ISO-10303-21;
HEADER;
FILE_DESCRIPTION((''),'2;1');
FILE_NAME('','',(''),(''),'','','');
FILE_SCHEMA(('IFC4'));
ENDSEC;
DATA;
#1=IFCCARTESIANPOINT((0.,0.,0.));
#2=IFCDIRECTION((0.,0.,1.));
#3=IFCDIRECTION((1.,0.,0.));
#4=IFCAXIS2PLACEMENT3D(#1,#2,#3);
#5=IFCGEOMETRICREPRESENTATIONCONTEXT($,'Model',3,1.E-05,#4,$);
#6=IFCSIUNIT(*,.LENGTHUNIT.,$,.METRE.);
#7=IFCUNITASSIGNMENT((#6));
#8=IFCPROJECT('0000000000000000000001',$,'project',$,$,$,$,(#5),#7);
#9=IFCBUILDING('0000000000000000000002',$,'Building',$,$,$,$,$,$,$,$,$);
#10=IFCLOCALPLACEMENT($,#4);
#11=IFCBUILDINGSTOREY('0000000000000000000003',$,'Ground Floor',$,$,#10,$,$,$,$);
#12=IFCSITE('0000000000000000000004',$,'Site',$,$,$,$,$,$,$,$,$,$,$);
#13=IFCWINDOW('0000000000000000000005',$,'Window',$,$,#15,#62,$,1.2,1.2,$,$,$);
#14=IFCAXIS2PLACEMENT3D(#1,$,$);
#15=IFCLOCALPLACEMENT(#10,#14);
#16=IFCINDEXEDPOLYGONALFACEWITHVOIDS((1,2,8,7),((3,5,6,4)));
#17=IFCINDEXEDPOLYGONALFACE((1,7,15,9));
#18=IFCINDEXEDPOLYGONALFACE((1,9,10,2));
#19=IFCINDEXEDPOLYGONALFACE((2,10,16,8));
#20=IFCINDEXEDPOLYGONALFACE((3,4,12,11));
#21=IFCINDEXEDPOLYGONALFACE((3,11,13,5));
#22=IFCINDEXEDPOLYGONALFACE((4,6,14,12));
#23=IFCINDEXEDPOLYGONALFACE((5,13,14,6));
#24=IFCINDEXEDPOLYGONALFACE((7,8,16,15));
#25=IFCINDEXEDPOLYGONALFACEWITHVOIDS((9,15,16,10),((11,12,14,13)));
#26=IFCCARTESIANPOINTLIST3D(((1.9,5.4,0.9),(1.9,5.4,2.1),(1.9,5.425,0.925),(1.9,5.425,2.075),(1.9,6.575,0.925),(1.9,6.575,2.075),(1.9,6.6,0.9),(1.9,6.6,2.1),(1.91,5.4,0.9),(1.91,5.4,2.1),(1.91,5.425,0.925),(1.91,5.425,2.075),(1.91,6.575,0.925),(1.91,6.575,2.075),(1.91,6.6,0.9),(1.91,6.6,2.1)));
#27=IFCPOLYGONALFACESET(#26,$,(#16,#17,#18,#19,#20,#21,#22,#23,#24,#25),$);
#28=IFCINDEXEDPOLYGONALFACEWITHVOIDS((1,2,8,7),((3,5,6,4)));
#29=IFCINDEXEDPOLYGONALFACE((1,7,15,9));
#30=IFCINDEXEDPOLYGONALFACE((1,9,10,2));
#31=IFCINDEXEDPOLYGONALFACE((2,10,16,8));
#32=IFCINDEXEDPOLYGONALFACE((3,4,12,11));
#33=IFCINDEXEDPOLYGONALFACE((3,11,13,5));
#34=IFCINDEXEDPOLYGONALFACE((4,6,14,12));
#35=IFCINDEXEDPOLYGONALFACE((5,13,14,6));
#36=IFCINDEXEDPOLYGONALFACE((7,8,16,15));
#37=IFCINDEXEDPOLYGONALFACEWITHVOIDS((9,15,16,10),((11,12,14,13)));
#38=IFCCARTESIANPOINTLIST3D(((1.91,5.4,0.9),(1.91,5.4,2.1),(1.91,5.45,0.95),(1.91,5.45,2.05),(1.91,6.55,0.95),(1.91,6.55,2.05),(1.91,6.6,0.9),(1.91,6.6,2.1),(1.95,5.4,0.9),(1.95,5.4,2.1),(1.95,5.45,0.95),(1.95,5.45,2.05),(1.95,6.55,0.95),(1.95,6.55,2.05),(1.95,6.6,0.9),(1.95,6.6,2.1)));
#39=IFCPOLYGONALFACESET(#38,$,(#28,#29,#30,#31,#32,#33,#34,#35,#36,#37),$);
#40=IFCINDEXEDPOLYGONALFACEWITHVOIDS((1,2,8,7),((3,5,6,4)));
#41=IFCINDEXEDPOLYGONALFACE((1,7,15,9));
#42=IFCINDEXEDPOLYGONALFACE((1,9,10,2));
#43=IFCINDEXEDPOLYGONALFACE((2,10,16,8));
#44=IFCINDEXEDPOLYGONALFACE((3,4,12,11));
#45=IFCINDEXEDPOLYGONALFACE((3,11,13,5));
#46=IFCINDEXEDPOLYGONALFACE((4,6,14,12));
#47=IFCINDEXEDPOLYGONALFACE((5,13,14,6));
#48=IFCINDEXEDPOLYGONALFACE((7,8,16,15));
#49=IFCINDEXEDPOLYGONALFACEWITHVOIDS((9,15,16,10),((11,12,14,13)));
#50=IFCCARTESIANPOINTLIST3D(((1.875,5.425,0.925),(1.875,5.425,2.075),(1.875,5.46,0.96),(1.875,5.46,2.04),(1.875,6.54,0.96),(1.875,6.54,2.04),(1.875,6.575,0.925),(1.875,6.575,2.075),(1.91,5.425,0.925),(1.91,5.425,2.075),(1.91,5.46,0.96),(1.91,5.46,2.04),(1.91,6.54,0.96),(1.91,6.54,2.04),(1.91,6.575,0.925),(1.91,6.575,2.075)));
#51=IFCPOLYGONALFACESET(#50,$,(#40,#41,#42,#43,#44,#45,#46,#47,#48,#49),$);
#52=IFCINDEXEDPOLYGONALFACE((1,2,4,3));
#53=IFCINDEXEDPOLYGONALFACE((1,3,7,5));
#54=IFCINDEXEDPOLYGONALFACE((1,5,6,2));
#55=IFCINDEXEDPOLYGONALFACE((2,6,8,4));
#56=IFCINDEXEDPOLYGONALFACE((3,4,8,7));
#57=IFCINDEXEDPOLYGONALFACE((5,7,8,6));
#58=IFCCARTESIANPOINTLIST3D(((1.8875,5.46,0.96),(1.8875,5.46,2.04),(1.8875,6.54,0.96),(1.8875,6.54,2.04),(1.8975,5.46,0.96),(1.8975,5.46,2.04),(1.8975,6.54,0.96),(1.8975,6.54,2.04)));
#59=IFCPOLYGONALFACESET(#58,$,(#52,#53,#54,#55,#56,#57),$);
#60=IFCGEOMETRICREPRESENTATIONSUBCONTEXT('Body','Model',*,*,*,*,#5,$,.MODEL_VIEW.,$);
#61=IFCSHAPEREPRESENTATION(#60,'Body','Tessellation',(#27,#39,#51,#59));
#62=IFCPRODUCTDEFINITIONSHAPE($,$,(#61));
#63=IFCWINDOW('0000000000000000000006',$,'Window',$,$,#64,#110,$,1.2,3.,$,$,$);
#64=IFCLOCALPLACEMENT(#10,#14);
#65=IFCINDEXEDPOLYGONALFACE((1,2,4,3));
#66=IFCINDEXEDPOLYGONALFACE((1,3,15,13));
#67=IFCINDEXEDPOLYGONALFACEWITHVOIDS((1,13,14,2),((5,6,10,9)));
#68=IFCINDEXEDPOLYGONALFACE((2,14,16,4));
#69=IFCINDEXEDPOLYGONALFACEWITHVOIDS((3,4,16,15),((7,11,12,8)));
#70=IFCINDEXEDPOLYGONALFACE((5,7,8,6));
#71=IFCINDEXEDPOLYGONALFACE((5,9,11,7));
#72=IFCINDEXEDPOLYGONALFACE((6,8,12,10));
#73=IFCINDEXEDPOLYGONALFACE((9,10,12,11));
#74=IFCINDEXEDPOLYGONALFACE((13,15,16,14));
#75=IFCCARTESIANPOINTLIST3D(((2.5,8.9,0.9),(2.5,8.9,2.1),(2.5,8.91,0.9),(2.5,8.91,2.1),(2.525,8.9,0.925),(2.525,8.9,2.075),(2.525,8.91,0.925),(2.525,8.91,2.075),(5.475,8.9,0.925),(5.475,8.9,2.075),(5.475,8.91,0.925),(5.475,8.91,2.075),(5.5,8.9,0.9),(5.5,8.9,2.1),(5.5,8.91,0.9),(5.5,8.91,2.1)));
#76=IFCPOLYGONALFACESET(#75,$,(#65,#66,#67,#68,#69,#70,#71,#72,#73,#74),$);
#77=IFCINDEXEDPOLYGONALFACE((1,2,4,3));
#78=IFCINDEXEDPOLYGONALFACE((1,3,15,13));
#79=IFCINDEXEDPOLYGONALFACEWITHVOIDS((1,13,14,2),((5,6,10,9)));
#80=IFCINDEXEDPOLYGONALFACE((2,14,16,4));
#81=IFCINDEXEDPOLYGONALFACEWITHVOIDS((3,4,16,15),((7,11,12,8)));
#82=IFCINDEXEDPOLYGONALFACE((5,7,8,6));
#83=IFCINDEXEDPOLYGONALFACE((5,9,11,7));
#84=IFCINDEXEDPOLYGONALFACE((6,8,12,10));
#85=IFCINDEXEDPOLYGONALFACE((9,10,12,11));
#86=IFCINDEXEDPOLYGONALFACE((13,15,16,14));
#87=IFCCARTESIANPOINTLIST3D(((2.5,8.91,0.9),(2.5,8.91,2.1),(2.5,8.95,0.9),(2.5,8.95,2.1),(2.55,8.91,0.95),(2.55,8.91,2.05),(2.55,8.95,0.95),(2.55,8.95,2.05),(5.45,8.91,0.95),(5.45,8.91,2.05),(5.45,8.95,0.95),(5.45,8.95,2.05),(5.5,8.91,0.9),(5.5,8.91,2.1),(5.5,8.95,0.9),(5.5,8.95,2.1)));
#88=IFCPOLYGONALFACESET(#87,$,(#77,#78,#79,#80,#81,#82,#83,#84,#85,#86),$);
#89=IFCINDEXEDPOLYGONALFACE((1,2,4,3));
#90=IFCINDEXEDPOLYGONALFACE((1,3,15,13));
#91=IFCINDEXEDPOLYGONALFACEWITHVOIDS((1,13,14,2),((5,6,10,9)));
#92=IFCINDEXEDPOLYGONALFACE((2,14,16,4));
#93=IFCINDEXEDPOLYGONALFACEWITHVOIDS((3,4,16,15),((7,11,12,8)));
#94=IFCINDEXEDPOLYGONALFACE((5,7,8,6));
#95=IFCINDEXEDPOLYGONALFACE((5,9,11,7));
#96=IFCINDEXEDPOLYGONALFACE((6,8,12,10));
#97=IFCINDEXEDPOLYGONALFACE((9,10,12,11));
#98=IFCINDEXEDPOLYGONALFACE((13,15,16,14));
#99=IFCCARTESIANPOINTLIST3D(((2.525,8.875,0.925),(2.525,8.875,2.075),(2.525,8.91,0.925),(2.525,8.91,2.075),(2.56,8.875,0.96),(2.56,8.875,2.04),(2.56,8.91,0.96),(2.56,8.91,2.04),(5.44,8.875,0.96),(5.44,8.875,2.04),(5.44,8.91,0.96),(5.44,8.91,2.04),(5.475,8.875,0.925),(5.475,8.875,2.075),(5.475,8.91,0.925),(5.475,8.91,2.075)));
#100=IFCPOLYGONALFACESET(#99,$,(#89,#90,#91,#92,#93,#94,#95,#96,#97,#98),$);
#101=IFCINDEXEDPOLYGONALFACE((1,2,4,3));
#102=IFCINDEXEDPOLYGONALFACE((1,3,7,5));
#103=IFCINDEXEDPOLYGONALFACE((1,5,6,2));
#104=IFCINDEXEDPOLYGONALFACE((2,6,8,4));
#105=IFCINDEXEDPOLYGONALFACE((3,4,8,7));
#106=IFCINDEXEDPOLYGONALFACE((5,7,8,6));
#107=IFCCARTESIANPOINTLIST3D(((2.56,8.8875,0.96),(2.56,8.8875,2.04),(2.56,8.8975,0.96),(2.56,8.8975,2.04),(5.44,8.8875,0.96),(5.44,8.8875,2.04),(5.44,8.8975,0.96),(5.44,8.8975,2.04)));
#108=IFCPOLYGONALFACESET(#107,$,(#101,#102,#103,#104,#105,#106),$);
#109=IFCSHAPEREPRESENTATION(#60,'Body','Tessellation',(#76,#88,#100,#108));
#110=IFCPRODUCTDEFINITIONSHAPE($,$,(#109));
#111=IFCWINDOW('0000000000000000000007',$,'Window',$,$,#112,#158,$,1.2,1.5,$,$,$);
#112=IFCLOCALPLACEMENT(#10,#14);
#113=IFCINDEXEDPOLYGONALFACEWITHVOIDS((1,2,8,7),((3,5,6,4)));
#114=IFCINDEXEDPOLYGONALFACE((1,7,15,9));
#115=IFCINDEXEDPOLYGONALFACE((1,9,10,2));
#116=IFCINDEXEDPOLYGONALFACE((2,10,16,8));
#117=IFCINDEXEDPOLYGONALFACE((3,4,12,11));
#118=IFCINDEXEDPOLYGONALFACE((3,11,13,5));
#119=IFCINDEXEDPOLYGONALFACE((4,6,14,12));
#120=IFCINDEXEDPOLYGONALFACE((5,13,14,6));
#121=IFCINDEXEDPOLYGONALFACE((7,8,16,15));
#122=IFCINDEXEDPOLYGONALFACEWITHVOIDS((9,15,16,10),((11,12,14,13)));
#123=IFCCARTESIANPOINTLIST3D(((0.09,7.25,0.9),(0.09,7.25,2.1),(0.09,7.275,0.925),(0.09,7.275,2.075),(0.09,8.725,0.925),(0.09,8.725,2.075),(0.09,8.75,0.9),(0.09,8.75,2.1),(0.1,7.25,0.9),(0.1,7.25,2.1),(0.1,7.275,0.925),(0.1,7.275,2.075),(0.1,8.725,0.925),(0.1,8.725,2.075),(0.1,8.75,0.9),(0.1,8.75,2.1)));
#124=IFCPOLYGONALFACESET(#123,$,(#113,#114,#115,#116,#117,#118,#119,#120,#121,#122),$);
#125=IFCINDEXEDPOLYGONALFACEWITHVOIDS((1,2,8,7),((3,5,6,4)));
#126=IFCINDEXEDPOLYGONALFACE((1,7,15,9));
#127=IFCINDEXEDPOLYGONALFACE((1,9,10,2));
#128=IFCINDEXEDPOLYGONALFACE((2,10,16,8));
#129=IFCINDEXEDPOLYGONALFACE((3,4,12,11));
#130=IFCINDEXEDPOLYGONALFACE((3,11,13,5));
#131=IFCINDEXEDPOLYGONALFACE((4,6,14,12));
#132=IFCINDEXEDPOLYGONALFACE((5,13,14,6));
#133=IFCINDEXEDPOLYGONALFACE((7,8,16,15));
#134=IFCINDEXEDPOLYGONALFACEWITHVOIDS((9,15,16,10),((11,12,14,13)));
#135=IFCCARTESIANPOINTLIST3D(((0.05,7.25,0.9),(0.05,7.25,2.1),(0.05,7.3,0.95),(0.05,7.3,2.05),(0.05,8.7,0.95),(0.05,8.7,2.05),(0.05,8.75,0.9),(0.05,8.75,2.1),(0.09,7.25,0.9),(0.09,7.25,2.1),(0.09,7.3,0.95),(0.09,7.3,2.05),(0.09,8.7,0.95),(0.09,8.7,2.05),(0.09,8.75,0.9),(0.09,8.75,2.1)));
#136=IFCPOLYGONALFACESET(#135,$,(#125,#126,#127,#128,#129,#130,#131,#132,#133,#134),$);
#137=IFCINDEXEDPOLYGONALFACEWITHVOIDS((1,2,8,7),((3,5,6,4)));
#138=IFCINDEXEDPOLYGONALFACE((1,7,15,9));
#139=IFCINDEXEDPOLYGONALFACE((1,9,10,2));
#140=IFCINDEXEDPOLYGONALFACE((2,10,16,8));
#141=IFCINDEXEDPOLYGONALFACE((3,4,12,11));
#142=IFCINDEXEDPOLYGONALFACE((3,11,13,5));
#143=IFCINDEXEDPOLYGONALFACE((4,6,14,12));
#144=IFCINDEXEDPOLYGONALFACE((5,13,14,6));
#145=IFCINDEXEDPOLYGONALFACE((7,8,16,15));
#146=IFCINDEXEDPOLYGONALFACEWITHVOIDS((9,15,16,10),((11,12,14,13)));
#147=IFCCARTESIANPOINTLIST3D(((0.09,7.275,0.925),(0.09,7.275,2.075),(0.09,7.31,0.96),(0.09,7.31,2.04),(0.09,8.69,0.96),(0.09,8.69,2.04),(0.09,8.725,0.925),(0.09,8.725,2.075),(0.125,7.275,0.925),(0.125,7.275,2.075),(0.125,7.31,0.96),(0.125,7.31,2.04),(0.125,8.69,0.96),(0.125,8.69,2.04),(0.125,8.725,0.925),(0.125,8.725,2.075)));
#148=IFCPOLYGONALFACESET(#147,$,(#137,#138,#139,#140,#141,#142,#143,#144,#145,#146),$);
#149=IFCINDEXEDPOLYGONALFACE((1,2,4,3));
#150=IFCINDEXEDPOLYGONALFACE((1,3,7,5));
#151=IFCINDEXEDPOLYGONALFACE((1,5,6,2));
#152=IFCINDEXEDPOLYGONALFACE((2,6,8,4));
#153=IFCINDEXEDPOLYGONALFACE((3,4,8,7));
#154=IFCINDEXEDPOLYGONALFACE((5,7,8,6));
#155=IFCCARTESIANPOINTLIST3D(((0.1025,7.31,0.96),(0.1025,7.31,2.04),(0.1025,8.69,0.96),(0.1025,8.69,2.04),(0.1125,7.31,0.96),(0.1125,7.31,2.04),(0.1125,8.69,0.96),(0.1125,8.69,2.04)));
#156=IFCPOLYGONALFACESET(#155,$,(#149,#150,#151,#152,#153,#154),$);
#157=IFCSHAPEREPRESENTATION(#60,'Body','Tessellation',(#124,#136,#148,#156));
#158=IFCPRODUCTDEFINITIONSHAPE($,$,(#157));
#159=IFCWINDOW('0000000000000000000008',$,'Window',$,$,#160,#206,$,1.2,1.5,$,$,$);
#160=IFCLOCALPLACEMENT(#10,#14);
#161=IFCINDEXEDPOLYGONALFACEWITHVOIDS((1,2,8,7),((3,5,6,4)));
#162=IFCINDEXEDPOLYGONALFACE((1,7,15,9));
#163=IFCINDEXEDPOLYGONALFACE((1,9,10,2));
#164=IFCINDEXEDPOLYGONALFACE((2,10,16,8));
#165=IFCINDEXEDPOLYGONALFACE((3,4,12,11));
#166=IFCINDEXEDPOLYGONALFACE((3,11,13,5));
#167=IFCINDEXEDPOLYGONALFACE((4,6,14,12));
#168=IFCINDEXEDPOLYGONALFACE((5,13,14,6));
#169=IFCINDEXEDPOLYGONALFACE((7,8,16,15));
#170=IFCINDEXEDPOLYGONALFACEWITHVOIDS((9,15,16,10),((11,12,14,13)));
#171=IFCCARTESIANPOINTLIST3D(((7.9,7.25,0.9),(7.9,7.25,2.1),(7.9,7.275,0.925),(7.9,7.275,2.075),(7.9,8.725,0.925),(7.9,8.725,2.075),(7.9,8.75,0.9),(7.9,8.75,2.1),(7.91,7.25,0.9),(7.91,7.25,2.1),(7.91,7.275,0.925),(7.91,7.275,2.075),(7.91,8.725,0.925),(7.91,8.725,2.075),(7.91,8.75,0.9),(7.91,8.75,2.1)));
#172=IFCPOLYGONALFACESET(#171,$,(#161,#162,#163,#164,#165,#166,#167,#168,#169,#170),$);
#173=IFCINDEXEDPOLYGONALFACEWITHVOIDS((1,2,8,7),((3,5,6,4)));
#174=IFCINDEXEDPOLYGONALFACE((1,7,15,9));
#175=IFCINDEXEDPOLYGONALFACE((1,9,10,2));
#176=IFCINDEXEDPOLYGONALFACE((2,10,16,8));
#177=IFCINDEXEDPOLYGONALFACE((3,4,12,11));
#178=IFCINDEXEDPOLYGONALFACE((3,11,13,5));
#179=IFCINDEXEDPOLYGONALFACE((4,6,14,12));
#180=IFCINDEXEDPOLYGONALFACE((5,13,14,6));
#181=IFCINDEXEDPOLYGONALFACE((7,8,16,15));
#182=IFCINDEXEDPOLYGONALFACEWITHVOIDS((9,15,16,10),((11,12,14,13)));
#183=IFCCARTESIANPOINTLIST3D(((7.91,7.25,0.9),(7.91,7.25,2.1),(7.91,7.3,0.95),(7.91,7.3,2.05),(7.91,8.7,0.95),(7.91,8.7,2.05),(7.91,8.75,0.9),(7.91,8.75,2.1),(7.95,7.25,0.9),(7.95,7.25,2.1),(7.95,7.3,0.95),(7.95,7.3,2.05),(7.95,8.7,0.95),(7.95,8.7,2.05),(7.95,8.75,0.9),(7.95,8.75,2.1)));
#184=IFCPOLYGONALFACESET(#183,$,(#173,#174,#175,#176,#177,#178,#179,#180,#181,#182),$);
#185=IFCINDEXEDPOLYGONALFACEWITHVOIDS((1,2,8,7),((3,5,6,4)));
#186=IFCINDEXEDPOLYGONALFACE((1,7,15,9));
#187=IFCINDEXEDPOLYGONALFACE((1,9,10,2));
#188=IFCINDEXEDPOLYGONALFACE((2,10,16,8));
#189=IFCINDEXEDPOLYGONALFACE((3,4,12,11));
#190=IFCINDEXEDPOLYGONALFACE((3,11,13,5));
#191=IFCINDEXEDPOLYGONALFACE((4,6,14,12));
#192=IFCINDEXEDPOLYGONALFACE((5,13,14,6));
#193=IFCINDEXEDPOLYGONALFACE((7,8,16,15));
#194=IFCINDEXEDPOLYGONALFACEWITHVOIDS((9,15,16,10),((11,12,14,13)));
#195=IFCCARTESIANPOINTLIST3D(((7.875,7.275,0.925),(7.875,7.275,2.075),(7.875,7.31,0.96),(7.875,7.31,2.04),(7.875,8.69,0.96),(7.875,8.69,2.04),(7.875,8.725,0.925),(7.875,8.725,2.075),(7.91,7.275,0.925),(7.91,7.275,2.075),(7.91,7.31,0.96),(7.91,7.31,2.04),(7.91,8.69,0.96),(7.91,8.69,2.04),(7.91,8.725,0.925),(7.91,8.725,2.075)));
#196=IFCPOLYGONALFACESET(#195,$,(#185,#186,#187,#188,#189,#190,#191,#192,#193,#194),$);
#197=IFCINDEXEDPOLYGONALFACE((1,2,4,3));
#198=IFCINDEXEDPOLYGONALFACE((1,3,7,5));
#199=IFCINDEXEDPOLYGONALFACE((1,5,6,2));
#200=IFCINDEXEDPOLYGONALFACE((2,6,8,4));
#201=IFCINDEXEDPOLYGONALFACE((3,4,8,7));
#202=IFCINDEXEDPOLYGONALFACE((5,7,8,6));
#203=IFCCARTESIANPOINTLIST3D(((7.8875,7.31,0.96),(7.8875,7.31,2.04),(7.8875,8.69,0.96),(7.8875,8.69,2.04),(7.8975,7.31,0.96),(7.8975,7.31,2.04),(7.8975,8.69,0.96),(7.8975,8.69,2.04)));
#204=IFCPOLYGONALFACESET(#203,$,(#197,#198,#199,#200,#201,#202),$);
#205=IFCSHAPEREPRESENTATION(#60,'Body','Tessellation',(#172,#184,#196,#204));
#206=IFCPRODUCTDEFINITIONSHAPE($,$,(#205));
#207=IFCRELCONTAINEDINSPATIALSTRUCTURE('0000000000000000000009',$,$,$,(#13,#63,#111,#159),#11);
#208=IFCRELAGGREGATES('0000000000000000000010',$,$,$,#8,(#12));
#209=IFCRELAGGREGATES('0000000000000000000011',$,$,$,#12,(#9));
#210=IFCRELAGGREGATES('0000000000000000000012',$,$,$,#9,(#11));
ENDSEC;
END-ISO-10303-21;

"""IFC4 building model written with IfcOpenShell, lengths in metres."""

from ifc_helpers import new_model, si_unit, frame, origin_with_axes, place, context, subcontext, project, spatial, line, indexed_curve, outline, extrude, element, save


model = new_model("IFC4")

# Units and contexts
model_context = context("Model", 3, precision=1e-05, world=origin_with_axes())
body_context = subcontext(model_context, "Body", "Model", "MODEL_VIEW")
ifc_project = project(units=[si_unit("LENGTHUNIT", "METRE")], contexts=[model_context])

# Site, building, storey
site = spatial("IfcSite", under=ifc_project, Name="Site")
building = spatial("IfcBuilding", under=site, Name="Building")
storey_placement = place(None, origin_with_axes())
storey = spatial("IfcBuildingStorey", under=building, at=storey_placement, Name="Ground Floor")

# Windows
window_1_placement = place(storey_placement, frame((2.0, 5.4, 0.9), z_axis=(0.0, 0.0, 1.0), x_axis=(0.0, 1.0, 0.0)))
element("IfcWindow", 1, at=window_1_placement, inside=storey, Name="Window", OverallHeight=1.2, OverallWidth=1.2, context=body_context, shape_type="SweptSolid", body=[
    extrude(outline(indexed_curve([(0.0, 0.0), (1.2, 0.0), (1.2, 1.2), (0.0, 1.2)], segments=[line(1, 2, 3, 4, 1)]), holes=[indexed_curve([(0.025, 0.025), (1.175, 0.025), (1.175, 1.175), (0.025, 1.175)], segments=[line(1, 2, 3, 4, 1)])]), frame((0.0, 0.09, 0.0), z_axis=(0.0, -1.0, 0.0), x_axis=(1.0, 0.0, 0.0)), (0.0, 0.0, -1.0), 0.01),
    extrude(outline(indexed_curve([(0.0, 0.0), (1.2, 0.0), (1.2, 1.2), (0.0, 1.2)], segments=[line(1, 2, 3, 4, 1)]), holes=[indexed_curve([(0.05, 0.05), (1.15, 0.05), (1.15, 1.15), (0.05, 1.15)], segments=[line(1, 2, 3, 4, 1)])]), frame((0.0, 0.05, 0.0), z_axis=(0.0, -1.0, 0.0), x_axis=(1.0, 0.0, 0.0)), (0.0, 0.0, -1.0), 0.04),
    extrude(outline(indexed_curve([(0.0, 0.0), (1.15, 0.0), (1.15, 1.15), (0.0, 1.15)], segments=[line(1, 2, 3, 4, 1)]), holes=[indexed_curve([(0.035, 0.035), (1.115, 0.035), (1.115, 1.115), (0.035, 1.115)], segments=[line(1, 2, 3, 4, 1)])]), frame((0.025, 0.09, 0.025), z_axis=(0.0, -1.0, 0.0), x_axis=(1.0, 0.0, 0.0)), (0.0, 0.0, -1.0), 0.035),
    extrude(outline(indexed_curve([(0.035, 0.035), (1.115, 0.035), (1.115, 1.115), (0.035, 1.115)], segments=[line(1, 2, 3, 4, 1)])), frame((0.025, 0.1025, 0.025), z_axis=(0.0, -1.0, 0.0), x_axis=(1.0, 0.0, 0.0)), (0.0, 0.0, -1.0), 0.01),
])
window_2_placement = place(storey_placement, frame((5.5, 9.0, 0.9), z_axis=(0.0, 0.0, 1.0), x_axis=(-1.0, 0.0, 0.0)))
element("IfcWindow", 2, at=window_2_placement, inside=storey, Name="Window", OverallHeight=1.2, OverallWidth=3.0, context=body_context, shape_type="SweptSolid", body=[
    extrude(outline(indexed_curve([(0.0, 0.0), (3.0, 0.0), (3.0, 1.2), (0.0, 1.2)], segments=[line(1, 2, 3, 4, 1)]), holes=[indexed_curve([(0.025, 0.025), (2.975, 0.025), (2.975, 1.175), (0.025, 1.175)], segments=[line(1, 2, 3, 4, 1)])]), frame((0.0, 0.09, 0.0), z_axis=(0.0, -1.0, 0.0), x_axis=(1.0, 0.0, 0.0)), (0.0, 0.0, -1.0), 0.01),
    extrude(outline(indexed_curve([(0.0, 0.0), (3.0, 0.0), (3.0, 1.2), (0.0, 1.2)], segments=[line(1, 2, 3, 4, 1)]), holes=[indexed_curve([(0.05, 0.05), (2.95, 0.05), (2.95, 1.15), (0.05, 1.15)], segments=[line(1, 2, 3, 4, 1)])]), frame((0.0, 0.05, 0.0), z_axis=(0.0, -1.0, 0.0), x_axis=(1.0, 0.0, 0.0)), (0.0, 0.0, -1.0), 0.04),
    extrude(outline(indexed_curve([(0.0, 0.0), (2.95, 0.0), (2.95, 1.15), (0.0, 1.15)], segments=[line(1, 2, 3, 4, 1)]), holes=[indexed_curve([(0.035, 0.035), (2.915, 0.035), (2.915, 1.115), (0.035, 1.115)], segments=[line(1, 2, 3, 4, 1)])]), frame((0.025, 0.09, 0.025), z_axis=(0.0, -1.0, 0.0), x_axis=(1.0, 0.0, 0.0)), (0.0, 0.0, -1.0), 0.035),
    extrude(outline(indexed_curve([(0.035, 0.035), (2.915, 0.035), (2.915, 1.115), (0.035, 1.115)], segments=[line(1, 2, 3, 4, 1)])), frame((0.025, 0.1025, 0.025), z_axis=(0.0, -1.0, 0.0), x_axis=(1.0, 0.0, 0.0)), (0.0, 0.0, -1.0), 0.01),
])
for number, where, z_axis, x_axis, name in (
    (3, (0.0, 8.75, 0.9), (0.0, 0.0, 1.0), (0.0, -1.0, 0.0), "Window"),
    (4, (8.0, 7.25, 0.9), (0.0, 0.0, 1.0), (0.0, 1.0, 0.0), "Window"),
):
    element("IfcWindow", number, at=place(storey_placement, frame(where, z_axis=z_axis, x_axis=x_axis)), inside=storey, Name=name, OverallHeight=1.2, OverallWidth=1.5, context=body_context, shape_type="SweptSolid", body=[
        extrude(outline(indexed_curve([(0.0, 0.0), (1.5, 0.0), (1.5, 1.2), (0.0, 1.2)], segments=[line(1, 2, 3, 4, 1)]), holes=[indexed_curve([(0.025, 0.025), (1.475, 0.025), (1.475, 1.175), (0.025, 1.175)], segments=[line(1, 2, 3, 4, 1)])]), frame((0.0, 0.09, 0.0), z_axis=(0.0, -1.0, 0.0), x_axis=(1.0, 0.0, 0.0)), (0.0, 0.0, -1.0), 0.01),
        extrude(outline(indexed_curve([(0.0, 0.0), (1.5, 0.0), (1.5, 1.2), (0.0, 1.2)], segments=[line(1, 2, 3, 4, 1)]), holes=[indexed_curve([(0.05, 0.05), (1.45, 0.05), (1.45, 1.15), (0.05, 1.15)], segments=[line(1, 2, 3, 4, 1)])]), frame((0.0, 0.05, 0.0), z_axis=(0.0, -1.0, 0.0), x_axis=(1.0, 0.0, 0.0)), (0.0, 0.0, -1.0), 0.04),
        extrude(outline(indexed_curve([(0.0, 0.0), (1.45, 0.0), (1.45, 1.15), (0.0, 1.15)], segments=[line(1, 2, 3, 4, 1)]), holes=[indexed_curve([(0.035, 0.035), (1.415, 0.035), (1.415, 1.115), (0.035, 1.115)], segments=[line(1, 2, 3, 4, 1)])]), frame((0.025, 0.09, 0.025), z_axis=(0.0, -1.0, 0.0), x_axis=(1.0, 0.0, 0.0)), (0.0, 0.0, -1.0), 0.035),
        extrude(outline(indexed_curve([(0.035, 0.035), (1.415, 0.035), (1.415, 1.115), (0.035, 1.115)], segments=[line(1, 2, 3, 4, 1)])), frame((0.025, 0.1025, 0.025), z_axis=(0.0, -1.0, 0.0), x_axis=(1.0, 0.0, 0.0)), (0.0, 0.0, -1.0), 0.01),
    ])

save(model, "model.ifc")
